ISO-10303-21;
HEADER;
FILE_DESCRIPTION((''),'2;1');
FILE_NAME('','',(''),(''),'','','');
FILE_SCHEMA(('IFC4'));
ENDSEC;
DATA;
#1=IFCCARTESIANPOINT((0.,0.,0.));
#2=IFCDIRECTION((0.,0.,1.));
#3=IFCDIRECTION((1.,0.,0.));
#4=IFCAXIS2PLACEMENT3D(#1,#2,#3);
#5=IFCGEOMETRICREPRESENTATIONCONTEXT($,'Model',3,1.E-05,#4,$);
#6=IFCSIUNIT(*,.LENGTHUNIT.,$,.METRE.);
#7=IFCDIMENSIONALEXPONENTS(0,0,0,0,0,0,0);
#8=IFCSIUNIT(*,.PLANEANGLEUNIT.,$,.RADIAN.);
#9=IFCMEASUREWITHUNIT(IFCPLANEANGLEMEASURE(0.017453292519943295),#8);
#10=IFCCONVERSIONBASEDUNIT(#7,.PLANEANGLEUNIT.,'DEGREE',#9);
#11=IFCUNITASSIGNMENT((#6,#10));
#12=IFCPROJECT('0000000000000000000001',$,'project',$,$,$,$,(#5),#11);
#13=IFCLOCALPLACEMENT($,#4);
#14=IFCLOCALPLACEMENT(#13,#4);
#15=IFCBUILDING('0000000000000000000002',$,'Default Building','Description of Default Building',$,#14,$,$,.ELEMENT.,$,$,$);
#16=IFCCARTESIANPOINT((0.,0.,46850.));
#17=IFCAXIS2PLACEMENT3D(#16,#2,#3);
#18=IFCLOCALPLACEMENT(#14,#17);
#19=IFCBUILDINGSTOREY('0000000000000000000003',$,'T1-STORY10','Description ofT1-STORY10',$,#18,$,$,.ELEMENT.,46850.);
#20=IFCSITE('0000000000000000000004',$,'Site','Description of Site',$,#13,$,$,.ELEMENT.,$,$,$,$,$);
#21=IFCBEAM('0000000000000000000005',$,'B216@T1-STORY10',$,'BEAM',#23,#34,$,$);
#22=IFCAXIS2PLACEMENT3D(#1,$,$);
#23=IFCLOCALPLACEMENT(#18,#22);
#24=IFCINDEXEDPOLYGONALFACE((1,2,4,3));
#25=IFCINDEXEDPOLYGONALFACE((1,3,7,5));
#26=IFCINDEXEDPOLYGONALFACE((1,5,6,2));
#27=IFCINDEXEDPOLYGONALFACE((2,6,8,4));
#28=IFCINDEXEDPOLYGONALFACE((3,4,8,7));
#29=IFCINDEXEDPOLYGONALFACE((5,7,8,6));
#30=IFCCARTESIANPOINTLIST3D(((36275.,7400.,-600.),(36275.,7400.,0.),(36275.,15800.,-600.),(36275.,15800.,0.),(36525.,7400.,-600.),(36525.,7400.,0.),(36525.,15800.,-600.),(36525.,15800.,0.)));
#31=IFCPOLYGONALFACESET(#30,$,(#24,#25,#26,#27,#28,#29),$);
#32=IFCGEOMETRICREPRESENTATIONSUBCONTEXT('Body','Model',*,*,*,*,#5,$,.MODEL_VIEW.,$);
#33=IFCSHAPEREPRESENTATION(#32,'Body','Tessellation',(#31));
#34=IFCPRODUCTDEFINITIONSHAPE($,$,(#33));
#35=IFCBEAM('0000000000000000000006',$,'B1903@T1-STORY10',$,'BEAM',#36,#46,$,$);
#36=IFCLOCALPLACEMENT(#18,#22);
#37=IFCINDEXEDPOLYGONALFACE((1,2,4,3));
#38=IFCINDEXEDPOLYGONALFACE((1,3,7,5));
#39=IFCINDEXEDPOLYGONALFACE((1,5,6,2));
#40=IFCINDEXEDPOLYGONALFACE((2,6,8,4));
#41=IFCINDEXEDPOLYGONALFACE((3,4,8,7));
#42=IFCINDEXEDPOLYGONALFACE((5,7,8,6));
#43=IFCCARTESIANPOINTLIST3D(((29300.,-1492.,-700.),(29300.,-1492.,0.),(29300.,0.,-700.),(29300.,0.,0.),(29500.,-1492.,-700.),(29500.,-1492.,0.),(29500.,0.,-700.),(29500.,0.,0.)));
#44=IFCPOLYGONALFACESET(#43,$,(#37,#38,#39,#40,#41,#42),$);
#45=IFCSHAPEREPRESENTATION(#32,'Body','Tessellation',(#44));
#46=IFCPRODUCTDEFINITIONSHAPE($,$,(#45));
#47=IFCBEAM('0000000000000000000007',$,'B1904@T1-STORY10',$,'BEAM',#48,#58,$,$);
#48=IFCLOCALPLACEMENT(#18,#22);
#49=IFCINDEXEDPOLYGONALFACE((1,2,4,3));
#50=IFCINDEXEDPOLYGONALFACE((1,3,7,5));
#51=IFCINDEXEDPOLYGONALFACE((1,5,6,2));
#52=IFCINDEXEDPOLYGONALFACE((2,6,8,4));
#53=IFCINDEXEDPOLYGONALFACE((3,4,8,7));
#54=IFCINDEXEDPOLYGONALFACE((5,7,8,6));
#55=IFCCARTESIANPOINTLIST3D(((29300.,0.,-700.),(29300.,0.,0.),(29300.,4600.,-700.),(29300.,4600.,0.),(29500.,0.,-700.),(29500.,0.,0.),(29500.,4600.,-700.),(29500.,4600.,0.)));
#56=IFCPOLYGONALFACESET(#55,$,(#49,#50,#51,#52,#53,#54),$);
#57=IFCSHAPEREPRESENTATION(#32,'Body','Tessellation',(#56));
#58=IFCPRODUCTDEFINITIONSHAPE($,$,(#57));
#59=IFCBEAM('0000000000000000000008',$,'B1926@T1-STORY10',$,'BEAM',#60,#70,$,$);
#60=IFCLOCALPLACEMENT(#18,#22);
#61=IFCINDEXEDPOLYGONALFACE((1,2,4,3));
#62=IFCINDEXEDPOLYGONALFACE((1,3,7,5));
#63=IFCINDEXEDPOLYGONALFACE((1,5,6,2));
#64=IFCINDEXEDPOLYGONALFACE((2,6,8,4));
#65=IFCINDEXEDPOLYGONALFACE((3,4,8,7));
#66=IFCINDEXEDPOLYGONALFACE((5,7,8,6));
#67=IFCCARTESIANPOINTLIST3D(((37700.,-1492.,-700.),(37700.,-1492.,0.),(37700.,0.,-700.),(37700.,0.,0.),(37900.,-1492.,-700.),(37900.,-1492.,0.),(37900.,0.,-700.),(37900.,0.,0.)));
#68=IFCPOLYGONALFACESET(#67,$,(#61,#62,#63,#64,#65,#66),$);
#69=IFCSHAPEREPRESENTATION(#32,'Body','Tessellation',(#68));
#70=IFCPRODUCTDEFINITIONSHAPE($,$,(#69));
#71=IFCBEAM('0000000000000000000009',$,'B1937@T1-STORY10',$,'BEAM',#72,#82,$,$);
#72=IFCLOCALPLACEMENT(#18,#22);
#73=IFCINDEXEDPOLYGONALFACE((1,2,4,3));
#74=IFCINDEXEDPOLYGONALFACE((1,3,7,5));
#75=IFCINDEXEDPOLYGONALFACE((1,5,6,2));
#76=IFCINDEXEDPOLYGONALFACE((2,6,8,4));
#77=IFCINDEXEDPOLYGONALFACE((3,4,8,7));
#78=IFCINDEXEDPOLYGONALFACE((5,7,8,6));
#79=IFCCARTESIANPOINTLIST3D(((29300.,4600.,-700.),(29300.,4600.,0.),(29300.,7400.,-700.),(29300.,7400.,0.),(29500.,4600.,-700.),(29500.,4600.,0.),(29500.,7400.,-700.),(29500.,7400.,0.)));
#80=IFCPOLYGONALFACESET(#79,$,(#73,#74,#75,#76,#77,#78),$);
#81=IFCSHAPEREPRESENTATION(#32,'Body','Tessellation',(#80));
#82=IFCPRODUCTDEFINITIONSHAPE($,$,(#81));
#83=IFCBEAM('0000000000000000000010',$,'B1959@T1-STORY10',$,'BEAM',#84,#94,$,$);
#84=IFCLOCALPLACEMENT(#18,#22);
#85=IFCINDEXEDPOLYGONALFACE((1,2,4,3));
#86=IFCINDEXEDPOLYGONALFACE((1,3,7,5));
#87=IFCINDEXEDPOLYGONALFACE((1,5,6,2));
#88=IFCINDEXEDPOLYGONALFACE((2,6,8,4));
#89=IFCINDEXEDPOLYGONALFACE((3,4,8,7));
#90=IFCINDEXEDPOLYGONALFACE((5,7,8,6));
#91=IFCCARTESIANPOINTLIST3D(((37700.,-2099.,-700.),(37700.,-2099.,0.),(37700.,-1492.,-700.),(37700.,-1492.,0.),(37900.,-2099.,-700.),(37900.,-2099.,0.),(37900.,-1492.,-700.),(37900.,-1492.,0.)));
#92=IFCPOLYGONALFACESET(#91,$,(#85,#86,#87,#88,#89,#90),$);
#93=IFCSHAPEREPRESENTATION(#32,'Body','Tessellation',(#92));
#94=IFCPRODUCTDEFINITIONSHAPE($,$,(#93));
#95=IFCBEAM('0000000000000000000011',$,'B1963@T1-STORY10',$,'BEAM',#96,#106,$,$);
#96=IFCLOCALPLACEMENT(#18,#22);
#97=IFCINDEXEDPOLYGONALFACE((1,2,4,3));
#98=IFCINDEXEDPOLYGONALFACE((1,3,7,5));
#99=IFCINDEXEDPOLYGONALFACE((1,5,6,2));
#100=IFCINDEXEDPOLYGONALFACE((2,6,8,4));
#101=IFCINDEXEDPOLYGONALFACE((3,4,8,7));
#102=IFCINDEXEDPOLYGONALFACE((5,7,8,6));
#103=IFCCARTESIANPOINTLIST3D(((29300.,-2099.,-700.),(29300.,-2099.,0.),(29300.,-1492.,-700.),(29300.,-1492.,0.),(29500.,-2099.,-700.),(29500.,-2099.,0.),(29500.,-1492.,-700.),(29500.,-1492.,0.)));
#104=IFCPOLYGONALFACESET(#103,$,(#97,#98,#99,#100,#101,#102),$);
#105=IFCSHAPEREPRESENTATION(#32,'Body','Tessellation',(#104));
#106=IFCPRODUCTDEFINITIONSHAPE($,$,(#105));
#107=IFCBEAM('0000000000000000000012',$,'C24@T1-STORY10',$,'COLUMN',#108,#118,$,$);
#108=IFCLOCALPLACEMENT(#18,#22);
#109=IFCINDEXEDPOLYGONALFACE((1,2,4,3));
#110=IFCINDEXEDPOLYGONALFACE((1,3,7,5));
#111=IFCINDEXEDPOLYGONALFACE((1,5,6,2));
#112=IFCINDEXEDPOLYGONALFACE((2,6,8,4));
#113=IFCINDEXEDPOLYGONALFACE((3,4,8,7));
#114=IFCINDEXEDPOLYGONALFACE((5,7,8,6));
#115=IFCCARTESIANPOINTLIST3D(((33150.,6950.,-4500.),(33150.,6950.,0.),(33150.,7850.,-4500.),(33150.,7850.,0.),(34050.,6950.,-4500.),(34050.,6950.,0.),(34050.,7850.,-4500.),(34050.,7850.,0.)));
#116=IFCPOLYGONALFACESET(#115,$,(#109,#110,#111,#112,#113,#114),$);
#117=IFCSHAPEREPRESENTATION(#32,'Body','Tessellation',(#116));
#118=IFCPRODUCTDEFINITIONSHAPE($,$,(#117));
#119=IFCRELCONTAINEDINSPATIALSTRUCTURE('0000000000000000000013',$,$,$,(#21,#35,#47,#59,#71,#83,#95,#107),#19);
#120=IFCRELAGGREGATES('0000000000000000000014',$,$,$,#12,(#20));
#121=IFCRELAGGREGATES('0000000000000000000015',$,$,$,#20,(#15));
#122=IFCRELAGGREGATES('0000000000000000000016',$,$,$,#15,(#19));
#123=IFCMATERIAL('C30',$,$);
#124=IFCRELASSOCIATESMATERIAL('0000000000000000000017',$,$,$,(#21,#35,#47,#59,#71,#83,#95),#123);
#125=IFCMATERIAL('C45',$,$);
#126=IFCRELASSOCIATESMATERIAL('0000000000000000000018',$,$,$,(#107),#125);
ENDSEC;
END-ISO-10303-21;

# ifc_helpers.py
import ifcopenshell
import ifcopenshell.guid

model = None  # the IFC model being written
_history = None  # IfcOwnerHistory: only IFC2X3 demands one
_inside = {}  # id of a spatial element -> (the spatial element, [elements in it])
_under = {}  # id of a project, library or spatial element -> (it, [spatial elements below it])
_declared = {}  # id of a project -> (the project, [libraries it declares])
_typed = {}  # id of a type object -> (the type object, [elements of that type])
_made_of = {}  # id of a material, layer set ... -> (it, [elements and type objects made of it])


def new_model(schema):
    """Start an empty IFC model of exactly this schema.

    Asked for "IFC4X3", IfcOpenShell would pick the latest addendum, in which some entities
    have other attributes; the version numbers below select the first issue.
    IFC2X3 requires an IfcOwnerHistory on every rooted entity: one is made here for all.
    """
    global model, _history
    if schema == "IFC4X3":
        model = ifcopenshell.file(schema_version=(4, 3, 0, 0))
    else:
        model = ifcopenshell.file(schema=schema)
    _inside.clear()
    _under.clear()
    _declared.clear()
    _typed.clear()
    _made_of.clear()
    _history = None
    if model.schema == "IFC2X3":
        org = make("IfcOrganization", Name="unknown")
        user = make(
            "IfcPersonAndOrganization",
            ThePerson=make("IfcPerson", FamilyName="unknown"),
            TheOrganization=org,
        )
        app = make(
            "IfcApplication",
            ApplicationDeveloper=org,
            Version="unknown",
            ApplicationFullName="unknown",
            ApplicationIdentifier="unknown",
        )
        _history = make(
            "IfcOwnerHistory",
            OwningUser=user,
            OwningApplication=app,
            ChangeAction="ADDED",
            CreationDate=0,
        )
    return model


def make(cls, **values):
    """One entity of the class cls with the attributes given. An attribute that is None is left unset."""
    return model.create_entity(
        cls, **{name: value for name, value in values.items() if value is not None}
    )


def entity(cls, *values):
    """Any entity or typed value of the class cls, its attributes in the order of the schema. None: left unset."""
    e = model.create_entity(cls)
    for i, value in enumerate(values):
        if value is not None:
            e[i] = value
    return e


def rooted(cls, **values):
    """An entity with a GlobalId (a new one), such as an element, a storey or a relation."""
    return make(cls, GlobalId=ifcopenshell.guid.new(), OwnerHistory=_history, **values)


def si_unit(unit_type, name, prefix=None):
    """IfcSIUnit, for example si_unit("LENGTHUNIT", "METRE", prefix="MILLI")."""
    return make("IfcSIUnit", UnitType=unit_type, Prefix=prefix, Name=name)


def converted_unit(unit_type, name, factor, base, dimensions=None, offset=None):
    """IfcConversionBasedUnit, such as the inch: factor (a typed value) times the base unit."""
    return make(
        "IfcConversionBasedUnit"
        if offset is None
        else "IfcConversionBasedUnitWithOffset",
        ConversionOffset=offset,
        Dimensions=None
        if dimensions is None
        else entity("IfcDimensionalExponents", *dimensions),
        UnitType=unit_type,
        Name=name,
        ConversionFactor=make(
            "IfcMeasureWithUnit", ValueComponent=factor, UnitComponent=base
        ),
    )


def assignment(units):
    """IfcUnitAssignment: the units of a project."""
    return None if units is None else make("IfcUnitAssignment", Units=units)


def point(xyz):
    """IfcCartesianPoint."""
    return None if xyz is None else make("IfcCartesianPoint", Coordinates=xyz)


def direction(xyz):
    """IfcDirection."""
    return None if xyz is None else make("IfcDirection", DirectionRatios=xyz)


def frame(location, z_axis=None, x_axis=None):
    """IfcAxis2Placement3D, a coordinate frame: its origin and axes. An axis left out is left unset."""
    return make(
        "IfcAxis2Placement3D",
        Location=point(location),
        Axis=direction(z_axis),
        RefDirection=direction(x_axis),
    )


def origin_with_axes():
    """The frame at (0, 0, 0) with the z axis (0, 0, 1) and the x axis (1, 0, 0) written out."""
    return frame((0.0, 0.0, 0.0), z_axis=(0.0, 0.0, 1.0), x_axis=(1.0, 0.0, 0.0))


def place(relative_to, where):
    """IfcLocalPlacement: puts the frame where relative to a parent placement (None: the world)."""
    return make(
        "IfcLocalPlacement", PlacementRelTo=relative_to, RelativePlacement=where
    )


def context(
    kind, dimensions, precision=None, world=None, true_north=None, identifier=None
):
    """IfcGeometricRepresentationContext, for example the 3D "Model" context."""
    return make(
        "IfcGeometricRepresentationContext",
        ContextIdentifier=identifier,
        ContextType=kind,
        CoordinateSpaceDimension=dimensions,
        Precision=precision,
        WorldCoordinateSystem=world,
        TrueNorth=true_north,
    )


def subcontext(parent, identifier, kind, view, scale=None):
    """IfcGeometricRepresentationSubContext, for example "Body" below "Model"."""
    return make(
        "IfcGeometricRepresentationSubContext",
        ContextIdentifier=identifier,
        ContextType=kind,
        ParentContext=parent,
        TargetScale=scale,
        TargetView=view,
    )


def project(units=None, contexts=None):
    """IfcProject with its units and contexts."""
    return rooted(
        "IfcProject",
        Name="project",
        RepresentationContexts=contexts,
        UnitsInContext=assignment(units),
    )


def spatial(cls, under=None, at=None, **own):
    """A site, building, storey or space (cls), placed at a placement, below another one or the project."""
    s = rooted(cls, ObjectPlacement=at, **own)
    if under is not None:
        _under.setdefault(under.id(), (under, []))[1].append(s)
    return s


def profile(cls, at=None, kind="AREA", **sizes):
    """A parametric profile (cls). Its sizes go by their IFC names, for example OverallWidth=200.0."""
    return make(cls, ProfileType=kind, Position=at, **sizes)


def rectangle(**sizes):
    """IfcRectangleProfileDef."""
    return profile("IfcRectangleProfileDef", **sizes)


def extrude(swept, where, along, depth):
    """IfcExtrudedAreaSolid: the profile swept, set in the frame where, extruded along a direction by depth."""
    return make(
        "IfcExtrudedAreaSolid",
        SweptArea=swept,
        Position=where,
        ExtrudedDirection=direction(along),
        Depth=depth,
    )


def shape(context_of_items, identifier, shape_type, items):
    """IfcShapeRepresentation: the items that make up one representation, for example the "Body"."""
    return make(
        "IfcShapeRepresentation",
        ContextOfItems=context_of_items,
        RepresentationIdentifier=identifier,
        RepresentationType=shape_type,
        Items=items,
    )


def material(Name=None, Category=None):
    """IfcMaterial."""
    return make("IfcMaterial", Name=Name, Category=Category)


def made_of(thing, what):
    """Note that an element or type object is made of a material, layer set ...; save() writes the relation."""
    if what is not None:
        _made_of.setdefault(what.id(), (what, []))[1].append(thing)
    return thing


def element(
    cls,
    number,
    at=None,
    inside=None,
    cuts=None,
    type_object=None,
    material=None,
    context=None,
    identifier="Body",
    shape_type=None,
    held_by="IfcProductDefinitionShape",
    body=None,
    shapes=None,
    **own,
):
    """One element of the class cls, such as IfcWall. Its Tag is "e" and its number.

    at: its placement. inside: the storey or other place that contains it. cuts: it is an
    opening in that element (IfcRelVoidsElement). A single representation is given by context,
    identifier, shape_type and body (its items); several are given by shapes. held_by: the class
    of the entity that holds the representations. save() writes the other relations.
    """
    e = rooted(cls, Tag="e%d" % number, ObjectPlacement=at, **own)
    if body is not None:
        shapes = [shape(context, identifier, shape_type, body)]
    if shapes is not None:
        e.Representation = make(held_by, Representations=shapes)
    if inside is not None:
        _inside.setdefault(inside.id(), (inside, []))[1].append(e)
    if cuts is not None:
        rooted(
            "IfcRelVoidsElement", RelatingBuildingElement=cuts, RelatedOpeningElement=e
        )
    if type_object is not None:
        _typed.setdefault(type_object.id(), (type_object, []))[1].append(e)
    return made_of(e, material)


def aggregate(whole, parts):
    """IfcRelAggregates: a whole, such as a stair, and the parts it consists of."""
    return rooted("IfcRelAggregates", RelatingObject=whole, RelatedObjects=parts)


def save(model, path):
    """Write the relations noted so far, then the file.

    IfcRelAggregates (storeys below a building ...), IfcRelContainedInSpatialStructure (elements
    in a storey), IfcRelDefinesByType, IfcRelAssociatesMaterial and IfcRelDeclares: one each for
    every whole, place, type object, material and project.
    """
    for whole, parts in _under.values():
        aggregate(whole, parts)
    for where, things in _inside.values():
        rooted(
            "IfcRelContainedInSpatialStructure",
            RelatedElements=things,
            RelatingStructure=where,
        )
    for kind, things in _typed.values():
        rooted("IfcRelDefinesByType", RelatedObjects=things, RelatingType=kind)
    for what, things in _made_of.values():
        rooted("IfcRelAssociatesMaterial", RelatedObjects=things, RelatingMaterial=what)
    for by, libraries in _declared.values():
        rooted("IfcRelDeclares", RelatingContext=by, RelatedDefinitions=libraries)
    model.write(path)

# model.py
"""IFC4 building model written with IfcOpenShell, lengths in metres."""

from ifc_helpers import new_model, entity, si_unit, converted_unit, frame, origin_with_axes, place, context, subcontext, project, spatial, rectangle, extrude, material, element, save


model = new_model("IFC4")

# Units and contexts
model_context = context("Model", 3, precision=1e-05, world=origin_with_axes())
body_context = subcontext(model_context, "Body", "Model", "MODEL_VIEW")
ifc_project = project(units=[si_unit("LENGTHUNIT", "METRE"), converted_unit("PLANEANGLEUNIT", "DEGREE", entity("IfcPlaneAngleMeasure", 0.017453292519943295), si_unit("PLANEANGLEUNIT", "RADIAN"), dimensions=[0, 0, 0, 0, 0, 0, 0])], contexts=[model_context])

# Site, building, storey
site_placement = place(None, origin_with_axes())
site = spatial("IfcSite", under=ifc_project, at=site_placement, Name="Site", Description="Description of Site", CompositionType="ELEMENT")
building_placement = place(site_placement, origin_with_axes())
building = spatial("IfcBuilding", under=site, at=building_placement, Name="Default Building", Description="Description of Default Building", CompositionType="ELEMENT")
storey_placement = place(building_placement, frame((0.0, 0.0, 46850.0), z_axis=(0.0, 0.0, 1.0), x_axis=(1.0, 0.0, 0.0)))
storey = spatial("IfcBuildingStorey", under=building, at=storey_placement, Name="T1-STORY10", Description="Description ofT1-STORY10", CompositionType="ELEMENT", Elevation=46850.0)

# Beams
ifc_material_1 = material(Name="C30")
for number, where, z_axis, x_axis, name in (
    (1, (36400.0, 7400.0, -300.0), (0.0, 1.0, 0.0), (-1.0, 0.0, 0.0), "B216@T1-STORY10"),
):
    element("IfcBeam", number, at=place(storey_placement, frame(where, z_axis=z_axis, x_axis=x_axis)), inside=storey, material=ifc_material_1, Name=name, ObjectType="BEAM", context=body_context, shape_type="SweptSolid", body=[
        extrude(rectangle(XDim=250.0, YDim=600.0), origin_with_axes(), (0.0, 0.0, 1.0), 8400.0),
    ])
beam_1_placement = place(storey_placement, frame((29400.0, -1492.0, -350.0), z_axis=(0.0, 1.0, 0.0), x_axis=(-1.0, 0.0, 0.0)))
element("IfcBeam", 2, at=beam_1_placement, inside=storey, material=ifc_material_1, Name="B1903@T1-STORY10", ObjectType="BEAM", context=body_context, shape_type="SweptSolid", body=[
    extrude(rectangle(XDim=200.0, YDim=700.0), origin_with_axes(), (0.0, 0.0, 1.0), 1492.0),
])
beam_2_placement = place(storey_placement, frame((29400.0, 0.0, -350.0), z_axis=(0.0, 1.0, 0.0), x_axis=(-1.0, 0.0, 0.0)))
element("IfcBeam", 3, at=beam_2_placement, inside=storey, material=ifc_material_1, Name="B1904@T1-STORY10", ObjectType="BEAM", context=body_context, shape_type="SweptSolid", body=[
    extrude(rectangle(XDim=200.0, YDim=700.0), origin_with_axes(), (0.0, 0.0, 1.0), 4600.0),
])
beam_3_placement = place(storey_placement, frame((37800.0, -1492.0, -350.0), z_axis=(0.0, 1.0, 0.0), x_axis=(-1.0, 0.0, 0.0)))
element("IfcBeam", 4, at=beam_3_placement, inside=storey, material=ifc_material_1, Name="B1926@T1-STORY10", ObjectType="BEAM", context=body_context, shape_type="SweptSolid", body=[
    extrude(rectangle(XDim=200.0, YDim=700.0), origin_with_axes(), (0.0, 0.0, 1.0), 1492.0),
])
beam_4_placement = place(storey_placement, frame((29400.0, 4600.0, -350.0), z_axis=(0.0, 1.0, 0.0), x_axis=(-1.0, 0.0, 0.0)))
element("IfcBeam", 5, at=beam_4_placement, inside=storey, material=ifc_material_1, Name="B1937@T1-STORY10", ObjectType="BEAM", context=body_context, shape_type="SweptSolid", body=[
    extrude(rectangle(XDim=200.0, YDim=700.0), origin_with_axes(), (0.0, 0.0, 1.0), 2800.0),
])
for number, where, z_axis, x_axis, name in (
    (6, (37800.0, -2099.0, -350.0), (0.0, 1.0, 0.0), (-1.0, 0.0, 0.0), "B1959@T1-STORY10"),
    (7, (29400.0, -2099.0, -350.0), (0.0, 1.0, 0.0), (-1.0, 0.0, 0.0), "B1963@T1-STORY10"),
):
    element("IfcBeam", number, at=place(storey_placement, frame(where, z_axis=z_axis, x_axis=x_axis)), inside=storey, material=ifc_material_1, Name=name, ObjectType="BEAM", context=body_context, shape_type="SweptSolid", body=[
        extrude(rectangle(XDim=200.0, YDim=700.0), origin_with_axes(), (0.0, 0.0, 1.0), 607.0),
    ])
ifc_material_2 = material(Name="C45")
beam_5_placement = place(storey_placement, frame((33600.0, 7400.0, -4500.0), z_axis=(0.0, 0.0, 1.0), x_axis=(-1.0, 0.0, 0.0)))
element("IfcBeam", 8, at=beam_5_placement, inside=storey, material=ifc_material_2, Name="C24@T1-STORY10", ObjectType="COLUMN", context=body_context, shape_type="SweptSolid", body=[
    extrude(rectangle(XDim=900.0, YDim=900.0), origin_with_axes(), (0.0, 0.0, 1.0), 4500.0),
])

save(model, "model.ifc")
